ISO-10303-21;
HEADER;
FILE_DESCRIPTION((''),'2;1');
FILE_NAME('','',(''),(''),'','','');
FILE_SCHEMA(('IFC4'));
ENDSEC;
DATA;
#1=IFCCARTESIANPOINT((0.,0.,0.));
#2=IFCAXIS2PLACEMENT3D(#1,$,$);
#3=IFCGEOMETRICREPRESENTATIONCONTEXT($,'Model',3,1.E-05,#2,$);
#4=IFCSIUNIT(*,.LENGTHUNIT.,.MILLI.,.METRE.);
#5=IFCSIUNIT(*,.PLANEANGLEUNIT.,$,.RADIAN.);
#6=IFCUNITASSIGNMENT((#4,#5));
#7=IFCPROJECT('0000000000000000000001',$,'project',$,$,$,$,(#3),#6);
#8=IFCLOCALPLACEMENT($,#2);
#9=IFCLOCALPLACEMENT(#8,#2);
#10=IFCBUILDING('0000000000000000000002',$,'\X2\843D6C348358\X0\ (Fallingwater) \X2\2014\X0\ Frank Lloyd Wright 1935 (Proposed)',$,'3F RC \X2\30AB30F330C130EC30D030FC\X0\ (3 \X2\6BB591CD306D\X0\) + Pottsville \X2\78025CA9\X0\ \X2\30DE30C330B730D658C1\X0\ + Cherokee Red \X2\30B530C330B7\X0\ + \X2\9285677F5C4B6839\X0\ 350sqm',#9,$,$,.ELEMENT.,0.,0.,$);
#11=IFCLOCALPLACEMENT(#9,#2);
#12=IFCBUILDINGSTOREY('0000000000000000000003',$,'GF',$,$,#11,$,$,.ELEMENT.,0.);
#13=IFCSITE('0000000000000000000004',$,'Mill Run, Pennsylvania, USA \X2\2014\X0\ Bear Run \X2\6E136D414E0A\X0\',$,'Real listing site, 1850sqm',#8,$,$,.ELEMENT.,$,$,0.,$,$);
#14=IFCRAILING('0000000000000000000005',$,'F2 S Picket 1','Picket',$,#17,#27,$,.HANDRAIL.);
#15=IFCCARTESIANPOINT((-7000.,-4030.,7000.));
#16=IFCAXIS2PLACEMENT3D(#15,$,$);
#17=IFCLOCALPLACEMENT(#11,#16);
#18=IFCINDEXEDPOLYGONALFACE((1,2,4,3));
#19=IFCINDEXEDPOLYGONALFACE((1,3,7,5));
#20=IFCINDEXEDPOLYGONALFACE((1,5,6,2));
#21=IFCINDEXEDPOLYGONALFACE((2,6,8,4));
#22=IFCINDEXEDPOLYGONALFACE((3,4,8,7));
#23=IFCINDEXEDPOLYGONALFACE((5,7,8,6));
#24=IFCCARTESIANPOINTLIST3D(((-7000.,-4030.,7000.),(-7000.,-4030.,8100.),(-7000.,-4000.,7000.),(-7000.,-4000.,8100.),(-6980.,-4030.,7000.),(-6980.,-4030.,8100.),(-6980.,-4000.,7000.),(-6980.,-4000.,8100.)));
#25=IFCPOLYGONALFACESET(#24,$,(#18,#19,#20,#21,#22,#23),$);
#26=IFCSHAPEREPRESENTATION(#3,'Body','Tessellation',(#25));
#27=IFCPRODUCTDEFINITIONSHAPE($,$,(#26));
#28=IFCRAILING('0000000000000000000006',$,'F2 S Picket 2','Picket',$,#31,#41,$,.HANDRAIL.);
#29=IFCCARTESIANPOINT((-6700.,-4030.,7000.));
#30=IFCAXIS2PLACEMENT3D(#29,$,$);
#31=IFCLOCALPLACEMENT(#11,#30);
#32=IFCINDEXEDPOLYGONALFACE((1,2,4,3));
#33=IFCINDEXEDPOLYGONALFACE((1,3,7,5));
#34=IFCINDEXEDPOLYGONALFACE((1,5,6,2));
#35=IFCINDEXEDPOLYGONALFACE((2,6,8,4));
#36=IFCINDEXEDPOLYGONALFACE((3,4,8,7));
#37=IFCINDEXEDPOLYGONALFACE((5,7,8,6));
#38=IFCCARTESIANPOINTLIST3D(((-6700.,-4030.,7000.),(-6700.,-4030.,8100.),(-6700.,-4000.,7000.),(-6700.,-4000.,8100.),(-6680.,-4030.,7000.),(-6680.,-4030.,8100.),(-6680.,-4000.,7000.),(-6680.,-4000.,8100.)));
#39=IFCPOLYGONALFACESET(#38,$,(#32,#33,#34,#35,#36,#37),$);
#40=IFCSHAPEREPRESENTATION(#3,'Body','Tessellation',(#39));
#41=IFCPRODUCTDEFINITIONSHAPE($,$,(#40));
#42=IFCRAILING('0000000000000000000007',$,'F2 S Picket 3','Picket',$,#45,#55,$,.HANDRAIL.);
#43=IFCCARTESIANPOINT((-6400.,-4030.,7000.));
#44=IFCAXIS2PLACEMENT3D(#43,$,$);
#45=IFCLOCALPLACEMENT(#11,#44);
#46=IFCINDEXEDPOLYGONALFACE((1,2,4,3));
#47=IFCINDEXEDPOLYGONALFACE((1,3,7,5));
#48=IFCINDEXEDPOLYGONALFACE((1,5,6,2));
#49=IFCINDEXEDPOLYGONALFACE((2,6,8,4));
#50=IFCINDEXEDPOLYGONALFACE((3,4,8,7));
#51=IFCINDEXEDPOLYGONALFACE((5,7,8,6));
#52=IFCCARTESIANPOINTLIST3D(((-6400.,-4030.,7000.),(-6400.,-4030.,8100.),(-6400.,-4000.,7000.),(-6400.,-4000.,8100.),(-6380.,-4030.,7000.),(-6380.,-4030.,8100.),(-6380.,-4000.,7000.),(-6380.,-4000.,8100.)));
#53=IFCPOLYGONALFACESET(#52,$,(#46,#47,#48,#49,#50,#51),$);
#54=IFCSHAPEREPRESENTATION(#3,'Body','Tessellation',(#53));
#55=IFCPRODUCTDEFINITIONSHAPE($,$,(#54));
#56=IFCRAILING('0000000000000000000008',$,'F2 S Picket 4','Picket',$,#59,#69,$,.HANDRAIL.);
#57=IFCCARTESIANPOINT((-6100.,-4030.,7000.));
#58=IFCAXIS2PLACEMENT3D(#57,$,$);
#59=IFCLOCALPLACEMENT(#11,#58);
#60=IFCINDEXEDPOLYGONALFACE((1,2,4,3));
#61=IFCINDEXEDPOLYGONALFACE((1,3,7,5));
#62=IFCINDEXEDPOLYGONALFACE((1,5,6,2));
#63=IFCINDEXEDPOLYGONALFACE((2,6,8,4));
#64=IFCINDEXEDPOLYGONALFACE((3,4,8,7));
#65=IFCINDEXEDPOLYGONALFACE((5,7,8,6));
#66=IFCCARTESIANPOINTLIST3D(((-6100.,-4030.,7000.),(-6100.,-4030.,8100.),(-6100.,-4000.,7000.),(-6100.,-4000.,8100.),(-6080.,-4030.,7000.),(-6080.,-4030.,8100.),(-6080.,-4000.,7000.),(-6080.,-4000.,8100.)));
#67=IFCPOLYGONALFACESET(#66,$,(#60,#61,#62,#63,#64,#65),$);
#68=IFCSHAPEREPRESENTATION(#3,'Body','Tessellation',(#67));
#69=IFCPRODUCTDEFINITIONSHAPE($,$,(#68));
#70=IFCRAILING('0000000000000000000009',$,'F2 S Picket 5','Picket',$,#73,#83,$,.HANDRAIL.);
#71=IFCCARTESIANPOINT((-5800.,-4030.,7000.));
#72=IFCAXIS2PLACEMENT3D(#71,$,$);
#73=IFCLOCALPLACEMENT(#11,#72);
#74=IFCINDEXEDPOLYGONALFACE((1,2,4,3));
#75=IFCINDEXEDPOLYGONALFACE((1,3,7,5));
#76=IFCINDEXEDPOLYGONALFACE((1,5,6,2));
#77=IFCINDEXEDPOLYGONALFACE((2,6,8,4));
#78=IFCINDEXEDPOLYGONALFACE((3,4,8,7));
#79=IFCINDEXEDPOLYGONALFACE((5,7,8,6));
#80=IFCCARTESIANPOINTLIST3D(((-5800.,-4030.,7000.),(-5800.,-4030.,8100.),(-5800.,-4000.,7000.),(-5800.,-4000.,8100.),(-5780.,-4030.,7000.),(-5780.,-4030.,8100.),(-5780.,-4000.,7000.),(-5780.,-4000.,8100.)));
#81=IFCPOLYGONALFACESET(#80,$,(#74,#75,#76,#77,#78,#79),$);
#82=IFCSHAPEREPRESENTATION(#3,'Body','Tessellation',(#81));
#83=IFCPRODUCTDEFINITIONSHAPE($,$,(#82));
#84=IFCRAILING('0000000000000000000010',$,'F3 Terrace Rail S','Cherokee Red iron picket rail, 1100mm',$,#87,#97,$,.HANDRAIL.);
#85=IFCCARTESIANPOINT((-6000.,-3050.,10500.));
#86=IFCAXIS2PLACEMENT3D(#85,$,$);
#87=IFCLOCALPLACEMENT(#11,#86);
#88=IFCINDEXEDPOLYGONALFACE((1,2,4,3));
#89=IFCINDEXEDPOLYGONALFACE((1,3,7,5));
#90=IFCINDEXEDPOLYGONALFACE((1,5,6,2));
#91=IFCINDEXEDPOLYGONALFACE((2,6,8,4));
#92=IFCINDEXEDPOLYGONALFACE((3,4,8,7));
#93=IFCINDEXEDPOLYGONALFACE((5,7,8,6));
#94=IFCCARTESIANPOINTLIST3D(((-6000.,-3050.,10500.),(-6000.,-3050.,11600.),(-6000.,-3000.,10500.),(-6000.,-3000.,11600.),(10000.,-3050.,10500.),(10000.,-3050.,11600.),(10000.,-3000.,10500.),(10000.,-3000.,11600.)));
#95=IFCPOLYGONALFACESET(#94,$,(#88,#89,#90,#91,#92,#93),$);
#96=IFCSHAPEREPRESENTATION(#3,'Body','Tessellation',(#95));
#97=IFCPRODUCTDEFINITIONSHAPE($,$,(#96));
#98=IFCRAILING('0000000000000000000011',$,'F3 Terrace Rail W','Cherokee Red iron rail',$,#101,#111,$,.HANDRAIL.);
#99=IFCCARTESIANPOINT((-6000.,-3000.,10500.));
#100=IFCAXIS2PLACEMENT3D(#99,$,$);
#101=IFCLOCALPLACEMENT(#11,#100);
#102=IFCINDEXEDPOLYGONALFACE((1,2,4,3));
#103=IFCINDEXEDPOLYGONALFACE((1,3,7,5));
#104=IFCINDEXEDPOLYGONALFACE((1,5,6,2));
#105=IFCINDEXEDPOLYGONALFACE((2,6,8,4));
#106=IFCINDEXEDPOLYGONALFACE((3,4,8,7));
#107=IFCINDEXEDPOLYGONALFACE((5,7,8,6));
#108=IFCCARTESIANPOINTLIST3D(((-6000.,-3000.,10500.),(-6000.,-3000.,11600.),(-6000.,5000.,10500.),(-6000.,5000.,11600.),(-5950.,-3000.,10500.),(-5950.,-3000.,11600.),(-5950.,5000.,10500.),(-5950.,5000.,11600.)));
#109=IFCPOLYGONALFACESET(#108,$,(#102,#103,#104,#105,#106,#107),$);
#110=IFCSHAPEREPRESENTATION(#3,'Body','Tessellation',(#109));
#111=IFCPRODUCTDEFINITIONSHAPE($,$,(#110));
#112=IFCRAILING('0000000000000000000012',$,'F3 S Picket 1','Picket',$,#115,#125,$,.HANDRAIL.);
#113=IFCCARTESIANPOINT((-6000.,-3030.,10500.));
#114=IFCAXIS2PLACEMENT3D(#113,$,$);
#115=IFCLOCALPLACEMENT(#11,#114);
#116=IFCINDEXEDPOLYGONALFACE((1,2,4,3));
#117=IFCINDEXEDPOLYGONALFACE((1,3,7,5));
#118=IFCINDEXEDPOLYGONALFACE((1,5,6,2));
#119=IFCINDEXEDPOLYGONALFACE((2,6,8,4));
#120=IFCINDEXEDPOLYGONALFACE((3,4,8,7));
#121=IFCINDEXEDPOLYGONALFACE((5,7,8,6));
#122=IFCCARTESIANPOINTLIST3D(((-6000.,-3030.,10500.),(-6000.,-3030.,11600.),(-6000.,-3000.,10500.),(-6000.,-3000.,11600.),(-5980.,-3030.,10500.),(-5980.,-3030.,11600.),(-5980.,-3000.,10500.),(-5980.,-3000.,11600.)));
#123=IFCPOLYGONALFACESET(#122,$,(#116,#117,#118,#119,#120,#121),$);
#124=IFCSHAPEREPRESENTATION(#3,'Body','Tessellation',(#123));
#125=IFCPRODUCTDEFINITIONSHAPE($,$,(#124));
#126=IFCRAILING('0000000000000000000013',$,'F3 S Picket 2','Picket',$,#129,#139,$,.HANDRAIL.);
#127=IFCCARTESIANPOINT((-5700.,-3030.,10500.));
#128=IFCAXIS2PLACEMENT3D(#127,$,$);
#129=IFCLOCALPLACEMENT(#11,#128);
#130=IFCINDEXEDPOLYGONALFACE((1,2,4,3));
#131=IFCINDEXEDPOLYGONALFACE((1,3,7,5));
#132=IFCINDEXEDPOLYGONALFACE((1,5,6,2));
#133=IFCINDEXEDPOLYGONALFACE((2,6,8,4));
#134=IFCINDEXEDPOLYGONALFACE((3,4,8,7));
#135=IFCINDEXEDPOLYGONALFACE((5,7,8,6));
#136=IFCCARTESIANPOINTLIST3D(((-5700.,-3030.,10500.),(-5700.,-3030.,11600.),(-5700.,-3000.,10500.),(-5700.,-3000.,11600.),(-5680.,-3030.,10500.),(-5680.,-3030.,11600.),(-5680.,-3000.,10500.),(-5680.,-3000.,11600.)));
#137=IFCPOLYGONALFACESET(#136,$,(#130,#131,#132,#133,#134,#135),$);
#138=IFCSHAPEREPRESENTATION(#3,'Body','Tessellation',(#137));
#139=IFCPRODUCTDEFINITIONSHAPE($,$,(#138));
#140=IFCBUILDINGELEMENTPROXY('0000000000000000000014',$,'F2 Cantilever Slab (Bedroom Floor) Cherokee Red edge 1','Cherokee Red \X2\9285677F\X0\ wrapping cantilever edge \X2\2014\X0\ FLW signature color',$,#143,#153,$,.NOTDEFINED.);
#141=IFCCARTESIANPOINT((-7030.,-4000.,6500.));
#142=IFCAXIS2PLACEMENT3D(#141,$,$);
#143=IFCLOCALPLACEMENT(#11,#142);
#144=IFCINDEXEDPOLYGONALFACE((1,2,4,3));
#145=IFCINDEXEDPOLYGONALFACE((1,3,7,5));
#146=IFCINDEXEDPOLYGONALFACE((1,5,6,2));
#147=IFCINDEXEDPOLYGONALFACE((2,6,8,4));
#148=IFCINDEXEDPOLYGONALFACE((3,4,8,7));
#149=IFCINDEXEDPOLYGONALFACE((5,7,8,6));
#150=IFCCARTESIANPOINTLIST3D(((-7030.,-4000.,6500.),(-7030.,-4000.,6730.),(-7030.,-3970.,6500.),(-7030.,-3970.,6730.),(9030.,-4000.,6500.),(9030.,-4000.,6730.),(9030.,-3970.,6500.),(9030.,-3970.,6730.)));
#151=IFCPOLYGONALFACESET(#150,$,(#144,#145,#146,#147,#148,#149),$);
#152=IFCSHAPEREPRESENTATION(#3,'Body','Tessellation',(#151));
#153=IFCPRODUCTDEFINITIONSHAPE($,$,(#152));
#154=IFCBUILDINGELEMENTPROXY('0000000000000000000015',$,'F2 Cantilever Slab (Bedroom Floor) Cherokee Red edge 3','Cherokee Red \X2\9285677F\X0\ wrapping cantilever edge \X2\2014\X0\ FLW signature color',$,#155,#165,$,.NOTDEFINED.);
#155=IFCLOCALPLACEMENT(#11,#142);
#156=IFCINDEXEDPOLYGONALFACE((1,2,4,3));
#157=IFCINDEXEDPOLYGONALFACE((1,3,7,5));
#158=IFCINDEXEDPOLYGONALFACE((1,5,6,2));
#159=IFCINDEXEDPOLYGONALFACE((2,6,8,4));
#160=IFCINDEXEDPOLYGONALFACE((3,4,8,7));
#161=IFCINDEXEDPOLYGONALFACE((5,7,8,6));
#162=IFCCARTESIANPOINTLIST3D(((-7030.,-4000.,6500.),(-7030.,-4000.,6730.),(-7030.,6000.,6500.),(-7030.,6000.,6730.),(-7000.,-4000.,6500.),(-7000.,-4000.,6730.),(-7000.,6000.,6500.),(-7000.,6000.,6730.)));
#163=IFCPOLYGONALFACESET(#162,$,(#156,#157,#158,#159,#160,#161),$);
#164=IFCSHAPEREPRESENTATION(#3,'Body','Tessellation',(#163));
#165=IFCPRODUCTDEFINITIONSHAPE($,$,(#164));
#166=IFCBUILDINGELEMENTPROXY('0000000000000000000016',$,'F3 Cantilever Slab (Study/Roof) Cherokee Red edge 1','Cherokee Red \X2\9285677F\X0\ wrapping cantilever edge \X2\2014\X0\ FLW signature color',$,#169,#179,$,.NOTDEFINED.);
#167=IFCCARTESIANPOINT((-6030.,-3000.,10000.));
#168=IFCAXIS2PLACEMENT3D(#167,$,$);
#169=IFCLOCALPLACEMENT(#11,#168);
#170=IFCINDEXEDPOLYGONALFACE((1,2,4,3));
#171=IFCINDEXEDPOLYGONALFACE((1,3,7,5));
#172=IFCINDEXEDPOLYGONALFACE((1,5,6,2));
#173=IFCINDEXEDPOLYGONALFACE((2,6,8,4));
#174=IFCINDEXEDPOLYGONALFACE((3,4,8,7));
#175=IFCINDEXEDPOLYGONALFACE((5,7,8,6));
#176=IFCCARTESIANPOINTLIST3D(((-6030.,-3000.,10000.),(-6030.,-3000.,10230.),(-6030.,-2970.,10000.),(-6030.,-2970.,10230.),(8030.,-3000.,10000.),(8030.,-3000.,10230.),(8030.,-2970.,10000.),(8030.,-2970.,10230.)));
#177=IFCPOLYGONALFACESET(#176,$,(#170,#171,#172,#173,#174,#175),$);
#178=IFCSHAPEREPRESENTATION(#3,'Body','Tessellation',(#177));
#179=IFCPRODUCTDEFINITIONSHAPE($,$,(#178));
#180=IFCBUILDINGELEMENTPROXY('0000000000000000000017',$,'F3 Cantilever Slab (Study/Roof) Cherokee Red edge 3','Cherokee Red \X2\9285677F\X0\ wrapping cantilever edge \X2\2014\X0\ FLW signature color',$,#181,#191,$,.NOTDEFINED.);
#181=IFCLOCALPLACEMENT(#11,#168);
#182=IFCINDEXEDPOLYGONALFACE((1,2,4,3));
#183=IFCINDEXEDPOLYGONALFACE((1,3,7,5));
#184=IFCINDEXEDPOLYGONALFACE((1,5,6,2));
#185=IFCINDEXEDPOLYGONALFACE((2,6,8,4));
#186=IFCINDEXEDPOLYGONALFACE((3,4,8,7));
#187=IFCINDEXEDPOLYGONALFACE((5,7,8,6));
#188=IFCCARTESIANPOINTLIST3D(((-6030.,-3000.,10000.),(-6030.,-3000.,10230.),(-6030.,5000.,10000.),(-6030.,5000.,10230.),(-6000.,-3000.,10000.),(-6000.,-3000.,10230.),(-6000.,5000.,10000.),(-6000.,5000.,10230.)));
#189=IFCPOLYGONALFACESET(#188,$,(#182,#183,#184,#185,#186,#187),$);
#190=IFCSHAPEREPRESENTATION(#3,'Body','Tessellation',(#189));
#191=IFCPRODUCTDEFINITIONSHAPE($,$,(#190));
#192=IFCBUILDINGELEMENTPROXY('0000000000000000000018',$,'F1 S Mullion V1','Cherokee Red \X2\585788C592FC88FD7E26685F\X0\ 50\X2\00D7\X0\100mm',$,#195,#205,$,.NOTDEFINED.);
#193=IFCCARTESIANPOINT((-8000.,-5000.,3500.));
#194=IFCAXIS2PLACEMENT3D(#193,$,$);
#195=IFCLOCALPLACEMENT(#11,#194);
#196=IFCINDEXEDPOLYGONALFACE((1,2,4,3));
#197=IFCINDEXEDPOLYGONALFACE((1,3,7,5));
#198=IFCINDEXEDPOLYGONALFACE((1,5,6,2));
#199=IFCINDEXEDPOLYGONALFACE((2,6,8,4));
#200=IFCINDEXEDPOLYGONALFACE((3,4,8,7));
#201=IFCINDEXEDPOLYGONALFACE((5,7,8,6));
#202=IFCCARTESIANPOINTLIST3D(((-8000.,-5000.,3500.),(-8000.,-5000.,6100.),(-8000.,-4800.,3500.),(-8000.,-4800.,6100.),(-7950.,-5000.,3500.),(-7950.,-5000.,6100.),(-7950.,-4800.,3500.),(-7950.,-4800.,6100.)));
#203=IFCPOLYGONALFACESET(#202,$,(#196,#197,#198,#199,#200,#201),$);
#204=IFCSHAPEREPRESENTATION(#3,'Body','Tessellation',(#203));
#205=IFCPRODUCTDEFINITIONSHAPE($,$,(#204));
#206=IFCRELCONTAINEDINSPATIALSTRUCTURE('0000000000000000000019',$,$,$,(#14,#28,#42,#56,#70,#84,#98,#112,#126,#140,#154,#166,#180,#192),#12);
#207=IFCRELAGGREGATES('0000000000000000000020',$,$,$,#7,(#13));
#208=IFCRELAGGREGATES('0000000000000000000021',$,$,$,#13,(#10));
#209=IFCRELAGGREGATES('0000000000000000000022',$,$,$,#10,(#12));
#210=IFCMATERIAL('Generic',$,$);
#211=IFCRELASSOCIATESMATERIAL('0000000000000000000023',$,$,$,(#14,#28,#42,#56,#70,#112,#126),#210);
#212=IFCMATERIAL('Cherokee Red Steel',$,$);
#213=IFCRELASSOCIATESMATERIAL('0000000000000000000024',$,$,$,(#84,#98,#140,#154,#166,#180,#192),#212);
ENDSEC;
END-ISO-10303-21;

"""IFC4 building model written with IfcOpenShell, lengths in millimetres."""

from ifc_helpers import new_model, si_unit, frame, frame_2d, origin, place, context, project, spatial, rectangle, extrude, material, element, save


model = new_model("IFC4")

# Units and contexts
model_context = context("Model", 3, precision=1e-05, world=origin())
ifc_project = project(units=[si_unit("LENGTHUNIT", "METRE", prefix="MILLI"), si_unit("PLANEANGLEUNIT", "RADIAN")], contexts=[model_context])

# Site, building, storey
site_placement = place(None, origin())
site = spatial("IfcSite", under=ifc_project, at=site_placement, Name="Mill Run, Pennsylvania, USA — Bear Run 渓流上", ObjectType="Real listing site, 1850sqm", CompositionType="ELEMENT", RefElevation=0.0)
building_placement = place(site_placement, origin())
building = spatial("IfcBuilding", under=site, at=building_placement, Name="落水荘 (Fallingwater) — Frank Lloyd Wright 1935 (Proposed)", ObjectType="3F RC カンチレバー (3 段重ね) + Pottsville 砂岩 マッシブ壁 + Cherokee Red サッシ + 銅板屋根 350sqm", CompositionType="ELEMENT", ElevationOfRefHeight=0.0, ElevationOfTerrain=0.0)
storey_placement = place(building_placement, origin())
storey = spatial("IfcBuildingStorey", under=building, at=storey_placement, Name="GF", CompositionType="ELEMENT", Elevation=0.0)

# Shared definitions
ifc_material_1 = material(Name="Cherokee Red Steel")

# Railings
ifc_material_2 = material(Name="Generic")
railing_1_placement = place(storey_placement, frame((-7000.0, -4030.0, 7000.0)))
element("IfcRailing", 1, at=railing_1_placement, inside=storey, material=ifc_material_2, Name="F2 S Picket 1", Description="Picket", PredefinedType="HANDRAIL", context=model_context, shape_type="SweptSolid", body=[
    extrude(rectangle(XDim=20.0, YDim=30.0, at=frame_2d((10.0, 15.0))), frame((-7000.0, -4030.0, 7000.0)), (0.0, 0.0, 1.0), 1100.0),
])
railing_2_placement = place(storey_placement, frame((-6700.0, -4030.0, 7000.0)))
element("IfcRailing", 2, at=railing_2_placement, inside=storey, material=ifc_material_2, Name="F2 S Picket 2", Description="Picket", PredefinedType="HANDRAIL", context=model_context, shape_type="SweptSolid", body=[
    extrude(rectangle(XDim=20.0, YDim=30.0, at=frame_2d((10.0, 15.0))), frame((-6700.0, -4030.0, 7000.0)), (0.0, 0.0, 1.0), 1100.0),
])
railing_3_placement = place(storey_placement, frame((-6400.0, -4030.0, 7000.0)))
element("IfcRailing", 3, at=railing_3_placement, inside=storey, material=ifc_material_2, Name="F2 S Picket 3", Description="Picket", PredefinedType="HANDRAIL", context=model_context, shape_type="SweptSolid", body=[
    extrude(rectangle(XDim=20.0, YDim=30.0, at=frame_2d((10.0, 15.0))), frame((-6400.0, -4030.0, 7000.0)), (0.0, 0.0, 1.0), 1100.0),
])
railing_4_placement = place(storey_placement, frame((-6100.0, -4030.0, 7000.0)))
element("IfcRailing", 4, at=railing_4_placement, inside=storey, material=ifc_material_2, Name="F2 S Picket 4", Description="Picket", PredefinedType="HANDRAIL", context=model_context, shape_type="SweptSolid", body=[
    extrude(rectangle(XDim=20.0, YDim=30.0, at=frame_2d((10.0, 15.0))), frame((-6100.0, -4030.0, 7000.0)), (0.0, 0.0, 1.0), 1100.0),
])
railing_5_placement = place(storey_placement, frame((-5800.0, -4030.0, 7000.0)))
element("IfcRailing", 5, at=railing_5_placement, inside=storey, material=ifc_material_2, Name="F2 S Picket 5", Description="Picket", PredefinedType="HANDRAIL", context=model_context, shape_type="SweptSolid", body=[
    extrude(rectangle(XDim=20.0, YDim=30.0, at=frame_2d((10.0, 15.0))), frame((-5800.0, -4030.0, 7000.0)), (0.0, 0.0, 1.0), 1100.0),
])
railing_6_placement = place(storey_placement, frame((-6000.0, -3050.0, 10500.0)))
element("IfcRailing", 6, at=railing_6_placement, inside=storey, material=ifc_material_1, Name="F3 Terrace Rail S", Description="Cherokee Red iron picket rail, 1100mm", PredefinedType="HANDRAIL", context=model_context, shape_type="SweptSolid", body=[
    extrude(rectangle(XDim=16000.0, YDim=50.0, at=frame_2d((8000.0, 25.0))), frame((-6000.0, -3050.0, 10500.0)), (0.0, 0.0, 1.0), 1100.0),
])
railing_7_placement = place(storey_placement, frame((-6000.0, -3000.0, 10500.0)))
element("IfcRailing", 7, at=railing_7_placement, inside=storey, material=ifc_material_1, Name="F3 Terrace Rail W", Description="Cherokee Red iron rail", PredefinedType="HANDRAIL", context=model_context, shape_type="SweptSolid", body=[
    extrude(rectangle(XDim=50.0, YDim=8000.0, at=frame_2d((25.0, 4000.0))), frame((-6000.0, -3000.0, 10500.0)), (0.0, 0.0, 1.0), 1100.0),
])
railing_8_placement = place(storey_placement, frame((-6000.0, -3030.0, 10500.0)))
element("IfcRailing", 8, at=railing_8_placement, inside=storey, material=ifc_material_2, Name="F3 S Picket 1", Description="Picket", PredefinedType="HANDRAIL", context=model_context, shape_type="SweptSolid", body=[
    extrude(rectangle(XDim=20.0, YDim=30.0, at=frame_2d((10.0, 15.0))), frame((-6000.0, -3030.0, 10500.0)), (0.0, 0.0, 1.0), 1100.0),
])
railing_9_placement = place(storey_placement, frame((-5700.0, -3030.0, 10500.0)))
element("IfcRailing", 9, at=railing_9_placement, inside=storey, material=ifc_material_2, Name="F3 S Picket 2", Description="Picket", PredefinedType="HANDRAIL", context=model_context, shape_type="SweptSolid", body=[
    extrude(rectangle(XDim=20.0, YDim=30.0, at=frame_2d((10.0, 15.0))), frame((-5700.0, -3030.0, 10500.0)), (0.0, 0.0, 1.0), 1100.0),
])

# Building element proxies
proxy_1_placement = place(storey_placement, frame((-7030.0, -4000.0, 6500.0)))
element("IfcBuildingElementProxy", 10, at=proxy_1_placement, inside=storey, material=ifc_material_1, Name="F2 Cantilever Slab (Bedroom Floor) Cherokee Red edge 1", Description="Cherokee Red 銅板 wrapping cantilever edge — FLW signature color", PredefinedType="NOTDEFINED", context=model_context, shape_type="SweptSolid", body=[
    extrude(rectangle(XDim=16060.0, YDim=30.0, at=frame_2d((8030.0, 15.0))), frame((-7030.0, -4000.0, 6500.0)), (0.0, 0.0, 1.0), 230.0),
])
proxy_2_placement = place(storey_placement, frame((-7030.0, -4000.0, 6500.0)))
element("IfcBuildingElementProxy", 11, at=proxy_2_placement, inside=storey, material=ifc_material_1, Name="F2 Cantilever Slab (Bedroom Floor) Cherokee Red edge 3", Description="Cherokee Red 銅板 wrapping cantilever edge — FLW signature color", PredefinedType="NOTDEFINED", context=model_context, shape_type="SweptSolid", body=[
    extrude(rectangle(XDim=30.0, YDim=10000.0, at=frame_2d((15.0, 5000.0))), frame((-7030.0, -4000.0, 6500.0)), (0.0, 0.0, 1.0), 230.0),
])
proxy_3_placement = place(storey_placement, frame((-6030.0, -3000.0, 10000.0)))
element("IfcBuildingElementProxy", 12, at=proxy_3_placement, inside=storey, material=ifc_material_1, Name="F3 Cantilever Slab (Study/Roof) Cherokee Red edge 1", Description="Cherokee Red 銅板 wrapping cantilever edge — FLW signature color", PredefinedType="NOTDEFINED", context=model_context, shape_type="SweptSolid", body=[
    extrude(rectangle(XDim=14060.0, YDim=30.0, at=frame_2d((7030.0, 15.0))), frame((-6030.0, -3000.0, 10000.0)), (0.0, 0.0, 1.0), 230.0),
])
proxy_4_placement = place(storey_placement, frame((-6030.0, -3000.0, 10000.0)))
element("IfcBuildingElementProxy", 13, at=proxy_4_placement, inside=storey, material=ifc_material_1, Name="F3 Cantilever Slab (Study/Roof) Cherokee Red edge 3", Description="Cherokee Red 銅板 wrapping cantilever edge — FLW signature color", PredefinedType="NOTDEFINED", context=model_context, shape_type="SweptSolid", body=[
    extrude(rectangle(XDim=30.0, YDim=8000.0, at=frame_2d((15.0, 4000.0))), frame((-6030.0, -3000.0, 10000.0)), (0.0, 0.0, 1.0), 230.0),
])
proxy_5_placement = place(storey_placement, frame((-8000.0, -5000.0, 3500.0)))
element("IfcBuildingElementProxy", 14, at=proxy_5_placement, inside=storey, material=ifc_material_1, Name="F1 S Mullion V1", Description="Cherokee Red 塗装鋼製縦桟 50×100mm", PredefinedType="NOTDEFINED", context=model_context, shape_type="SweptSolid", body=[
    extrude(rectangle(XDim=50.0, YDim=200.0, at=frame_2d((25.0, 100.0))), frame((-8000.0, -5000.0, 3500.0)), (0.0, 0.0, 1.0), 2600.0),
])

save(model, "model.ifc")
